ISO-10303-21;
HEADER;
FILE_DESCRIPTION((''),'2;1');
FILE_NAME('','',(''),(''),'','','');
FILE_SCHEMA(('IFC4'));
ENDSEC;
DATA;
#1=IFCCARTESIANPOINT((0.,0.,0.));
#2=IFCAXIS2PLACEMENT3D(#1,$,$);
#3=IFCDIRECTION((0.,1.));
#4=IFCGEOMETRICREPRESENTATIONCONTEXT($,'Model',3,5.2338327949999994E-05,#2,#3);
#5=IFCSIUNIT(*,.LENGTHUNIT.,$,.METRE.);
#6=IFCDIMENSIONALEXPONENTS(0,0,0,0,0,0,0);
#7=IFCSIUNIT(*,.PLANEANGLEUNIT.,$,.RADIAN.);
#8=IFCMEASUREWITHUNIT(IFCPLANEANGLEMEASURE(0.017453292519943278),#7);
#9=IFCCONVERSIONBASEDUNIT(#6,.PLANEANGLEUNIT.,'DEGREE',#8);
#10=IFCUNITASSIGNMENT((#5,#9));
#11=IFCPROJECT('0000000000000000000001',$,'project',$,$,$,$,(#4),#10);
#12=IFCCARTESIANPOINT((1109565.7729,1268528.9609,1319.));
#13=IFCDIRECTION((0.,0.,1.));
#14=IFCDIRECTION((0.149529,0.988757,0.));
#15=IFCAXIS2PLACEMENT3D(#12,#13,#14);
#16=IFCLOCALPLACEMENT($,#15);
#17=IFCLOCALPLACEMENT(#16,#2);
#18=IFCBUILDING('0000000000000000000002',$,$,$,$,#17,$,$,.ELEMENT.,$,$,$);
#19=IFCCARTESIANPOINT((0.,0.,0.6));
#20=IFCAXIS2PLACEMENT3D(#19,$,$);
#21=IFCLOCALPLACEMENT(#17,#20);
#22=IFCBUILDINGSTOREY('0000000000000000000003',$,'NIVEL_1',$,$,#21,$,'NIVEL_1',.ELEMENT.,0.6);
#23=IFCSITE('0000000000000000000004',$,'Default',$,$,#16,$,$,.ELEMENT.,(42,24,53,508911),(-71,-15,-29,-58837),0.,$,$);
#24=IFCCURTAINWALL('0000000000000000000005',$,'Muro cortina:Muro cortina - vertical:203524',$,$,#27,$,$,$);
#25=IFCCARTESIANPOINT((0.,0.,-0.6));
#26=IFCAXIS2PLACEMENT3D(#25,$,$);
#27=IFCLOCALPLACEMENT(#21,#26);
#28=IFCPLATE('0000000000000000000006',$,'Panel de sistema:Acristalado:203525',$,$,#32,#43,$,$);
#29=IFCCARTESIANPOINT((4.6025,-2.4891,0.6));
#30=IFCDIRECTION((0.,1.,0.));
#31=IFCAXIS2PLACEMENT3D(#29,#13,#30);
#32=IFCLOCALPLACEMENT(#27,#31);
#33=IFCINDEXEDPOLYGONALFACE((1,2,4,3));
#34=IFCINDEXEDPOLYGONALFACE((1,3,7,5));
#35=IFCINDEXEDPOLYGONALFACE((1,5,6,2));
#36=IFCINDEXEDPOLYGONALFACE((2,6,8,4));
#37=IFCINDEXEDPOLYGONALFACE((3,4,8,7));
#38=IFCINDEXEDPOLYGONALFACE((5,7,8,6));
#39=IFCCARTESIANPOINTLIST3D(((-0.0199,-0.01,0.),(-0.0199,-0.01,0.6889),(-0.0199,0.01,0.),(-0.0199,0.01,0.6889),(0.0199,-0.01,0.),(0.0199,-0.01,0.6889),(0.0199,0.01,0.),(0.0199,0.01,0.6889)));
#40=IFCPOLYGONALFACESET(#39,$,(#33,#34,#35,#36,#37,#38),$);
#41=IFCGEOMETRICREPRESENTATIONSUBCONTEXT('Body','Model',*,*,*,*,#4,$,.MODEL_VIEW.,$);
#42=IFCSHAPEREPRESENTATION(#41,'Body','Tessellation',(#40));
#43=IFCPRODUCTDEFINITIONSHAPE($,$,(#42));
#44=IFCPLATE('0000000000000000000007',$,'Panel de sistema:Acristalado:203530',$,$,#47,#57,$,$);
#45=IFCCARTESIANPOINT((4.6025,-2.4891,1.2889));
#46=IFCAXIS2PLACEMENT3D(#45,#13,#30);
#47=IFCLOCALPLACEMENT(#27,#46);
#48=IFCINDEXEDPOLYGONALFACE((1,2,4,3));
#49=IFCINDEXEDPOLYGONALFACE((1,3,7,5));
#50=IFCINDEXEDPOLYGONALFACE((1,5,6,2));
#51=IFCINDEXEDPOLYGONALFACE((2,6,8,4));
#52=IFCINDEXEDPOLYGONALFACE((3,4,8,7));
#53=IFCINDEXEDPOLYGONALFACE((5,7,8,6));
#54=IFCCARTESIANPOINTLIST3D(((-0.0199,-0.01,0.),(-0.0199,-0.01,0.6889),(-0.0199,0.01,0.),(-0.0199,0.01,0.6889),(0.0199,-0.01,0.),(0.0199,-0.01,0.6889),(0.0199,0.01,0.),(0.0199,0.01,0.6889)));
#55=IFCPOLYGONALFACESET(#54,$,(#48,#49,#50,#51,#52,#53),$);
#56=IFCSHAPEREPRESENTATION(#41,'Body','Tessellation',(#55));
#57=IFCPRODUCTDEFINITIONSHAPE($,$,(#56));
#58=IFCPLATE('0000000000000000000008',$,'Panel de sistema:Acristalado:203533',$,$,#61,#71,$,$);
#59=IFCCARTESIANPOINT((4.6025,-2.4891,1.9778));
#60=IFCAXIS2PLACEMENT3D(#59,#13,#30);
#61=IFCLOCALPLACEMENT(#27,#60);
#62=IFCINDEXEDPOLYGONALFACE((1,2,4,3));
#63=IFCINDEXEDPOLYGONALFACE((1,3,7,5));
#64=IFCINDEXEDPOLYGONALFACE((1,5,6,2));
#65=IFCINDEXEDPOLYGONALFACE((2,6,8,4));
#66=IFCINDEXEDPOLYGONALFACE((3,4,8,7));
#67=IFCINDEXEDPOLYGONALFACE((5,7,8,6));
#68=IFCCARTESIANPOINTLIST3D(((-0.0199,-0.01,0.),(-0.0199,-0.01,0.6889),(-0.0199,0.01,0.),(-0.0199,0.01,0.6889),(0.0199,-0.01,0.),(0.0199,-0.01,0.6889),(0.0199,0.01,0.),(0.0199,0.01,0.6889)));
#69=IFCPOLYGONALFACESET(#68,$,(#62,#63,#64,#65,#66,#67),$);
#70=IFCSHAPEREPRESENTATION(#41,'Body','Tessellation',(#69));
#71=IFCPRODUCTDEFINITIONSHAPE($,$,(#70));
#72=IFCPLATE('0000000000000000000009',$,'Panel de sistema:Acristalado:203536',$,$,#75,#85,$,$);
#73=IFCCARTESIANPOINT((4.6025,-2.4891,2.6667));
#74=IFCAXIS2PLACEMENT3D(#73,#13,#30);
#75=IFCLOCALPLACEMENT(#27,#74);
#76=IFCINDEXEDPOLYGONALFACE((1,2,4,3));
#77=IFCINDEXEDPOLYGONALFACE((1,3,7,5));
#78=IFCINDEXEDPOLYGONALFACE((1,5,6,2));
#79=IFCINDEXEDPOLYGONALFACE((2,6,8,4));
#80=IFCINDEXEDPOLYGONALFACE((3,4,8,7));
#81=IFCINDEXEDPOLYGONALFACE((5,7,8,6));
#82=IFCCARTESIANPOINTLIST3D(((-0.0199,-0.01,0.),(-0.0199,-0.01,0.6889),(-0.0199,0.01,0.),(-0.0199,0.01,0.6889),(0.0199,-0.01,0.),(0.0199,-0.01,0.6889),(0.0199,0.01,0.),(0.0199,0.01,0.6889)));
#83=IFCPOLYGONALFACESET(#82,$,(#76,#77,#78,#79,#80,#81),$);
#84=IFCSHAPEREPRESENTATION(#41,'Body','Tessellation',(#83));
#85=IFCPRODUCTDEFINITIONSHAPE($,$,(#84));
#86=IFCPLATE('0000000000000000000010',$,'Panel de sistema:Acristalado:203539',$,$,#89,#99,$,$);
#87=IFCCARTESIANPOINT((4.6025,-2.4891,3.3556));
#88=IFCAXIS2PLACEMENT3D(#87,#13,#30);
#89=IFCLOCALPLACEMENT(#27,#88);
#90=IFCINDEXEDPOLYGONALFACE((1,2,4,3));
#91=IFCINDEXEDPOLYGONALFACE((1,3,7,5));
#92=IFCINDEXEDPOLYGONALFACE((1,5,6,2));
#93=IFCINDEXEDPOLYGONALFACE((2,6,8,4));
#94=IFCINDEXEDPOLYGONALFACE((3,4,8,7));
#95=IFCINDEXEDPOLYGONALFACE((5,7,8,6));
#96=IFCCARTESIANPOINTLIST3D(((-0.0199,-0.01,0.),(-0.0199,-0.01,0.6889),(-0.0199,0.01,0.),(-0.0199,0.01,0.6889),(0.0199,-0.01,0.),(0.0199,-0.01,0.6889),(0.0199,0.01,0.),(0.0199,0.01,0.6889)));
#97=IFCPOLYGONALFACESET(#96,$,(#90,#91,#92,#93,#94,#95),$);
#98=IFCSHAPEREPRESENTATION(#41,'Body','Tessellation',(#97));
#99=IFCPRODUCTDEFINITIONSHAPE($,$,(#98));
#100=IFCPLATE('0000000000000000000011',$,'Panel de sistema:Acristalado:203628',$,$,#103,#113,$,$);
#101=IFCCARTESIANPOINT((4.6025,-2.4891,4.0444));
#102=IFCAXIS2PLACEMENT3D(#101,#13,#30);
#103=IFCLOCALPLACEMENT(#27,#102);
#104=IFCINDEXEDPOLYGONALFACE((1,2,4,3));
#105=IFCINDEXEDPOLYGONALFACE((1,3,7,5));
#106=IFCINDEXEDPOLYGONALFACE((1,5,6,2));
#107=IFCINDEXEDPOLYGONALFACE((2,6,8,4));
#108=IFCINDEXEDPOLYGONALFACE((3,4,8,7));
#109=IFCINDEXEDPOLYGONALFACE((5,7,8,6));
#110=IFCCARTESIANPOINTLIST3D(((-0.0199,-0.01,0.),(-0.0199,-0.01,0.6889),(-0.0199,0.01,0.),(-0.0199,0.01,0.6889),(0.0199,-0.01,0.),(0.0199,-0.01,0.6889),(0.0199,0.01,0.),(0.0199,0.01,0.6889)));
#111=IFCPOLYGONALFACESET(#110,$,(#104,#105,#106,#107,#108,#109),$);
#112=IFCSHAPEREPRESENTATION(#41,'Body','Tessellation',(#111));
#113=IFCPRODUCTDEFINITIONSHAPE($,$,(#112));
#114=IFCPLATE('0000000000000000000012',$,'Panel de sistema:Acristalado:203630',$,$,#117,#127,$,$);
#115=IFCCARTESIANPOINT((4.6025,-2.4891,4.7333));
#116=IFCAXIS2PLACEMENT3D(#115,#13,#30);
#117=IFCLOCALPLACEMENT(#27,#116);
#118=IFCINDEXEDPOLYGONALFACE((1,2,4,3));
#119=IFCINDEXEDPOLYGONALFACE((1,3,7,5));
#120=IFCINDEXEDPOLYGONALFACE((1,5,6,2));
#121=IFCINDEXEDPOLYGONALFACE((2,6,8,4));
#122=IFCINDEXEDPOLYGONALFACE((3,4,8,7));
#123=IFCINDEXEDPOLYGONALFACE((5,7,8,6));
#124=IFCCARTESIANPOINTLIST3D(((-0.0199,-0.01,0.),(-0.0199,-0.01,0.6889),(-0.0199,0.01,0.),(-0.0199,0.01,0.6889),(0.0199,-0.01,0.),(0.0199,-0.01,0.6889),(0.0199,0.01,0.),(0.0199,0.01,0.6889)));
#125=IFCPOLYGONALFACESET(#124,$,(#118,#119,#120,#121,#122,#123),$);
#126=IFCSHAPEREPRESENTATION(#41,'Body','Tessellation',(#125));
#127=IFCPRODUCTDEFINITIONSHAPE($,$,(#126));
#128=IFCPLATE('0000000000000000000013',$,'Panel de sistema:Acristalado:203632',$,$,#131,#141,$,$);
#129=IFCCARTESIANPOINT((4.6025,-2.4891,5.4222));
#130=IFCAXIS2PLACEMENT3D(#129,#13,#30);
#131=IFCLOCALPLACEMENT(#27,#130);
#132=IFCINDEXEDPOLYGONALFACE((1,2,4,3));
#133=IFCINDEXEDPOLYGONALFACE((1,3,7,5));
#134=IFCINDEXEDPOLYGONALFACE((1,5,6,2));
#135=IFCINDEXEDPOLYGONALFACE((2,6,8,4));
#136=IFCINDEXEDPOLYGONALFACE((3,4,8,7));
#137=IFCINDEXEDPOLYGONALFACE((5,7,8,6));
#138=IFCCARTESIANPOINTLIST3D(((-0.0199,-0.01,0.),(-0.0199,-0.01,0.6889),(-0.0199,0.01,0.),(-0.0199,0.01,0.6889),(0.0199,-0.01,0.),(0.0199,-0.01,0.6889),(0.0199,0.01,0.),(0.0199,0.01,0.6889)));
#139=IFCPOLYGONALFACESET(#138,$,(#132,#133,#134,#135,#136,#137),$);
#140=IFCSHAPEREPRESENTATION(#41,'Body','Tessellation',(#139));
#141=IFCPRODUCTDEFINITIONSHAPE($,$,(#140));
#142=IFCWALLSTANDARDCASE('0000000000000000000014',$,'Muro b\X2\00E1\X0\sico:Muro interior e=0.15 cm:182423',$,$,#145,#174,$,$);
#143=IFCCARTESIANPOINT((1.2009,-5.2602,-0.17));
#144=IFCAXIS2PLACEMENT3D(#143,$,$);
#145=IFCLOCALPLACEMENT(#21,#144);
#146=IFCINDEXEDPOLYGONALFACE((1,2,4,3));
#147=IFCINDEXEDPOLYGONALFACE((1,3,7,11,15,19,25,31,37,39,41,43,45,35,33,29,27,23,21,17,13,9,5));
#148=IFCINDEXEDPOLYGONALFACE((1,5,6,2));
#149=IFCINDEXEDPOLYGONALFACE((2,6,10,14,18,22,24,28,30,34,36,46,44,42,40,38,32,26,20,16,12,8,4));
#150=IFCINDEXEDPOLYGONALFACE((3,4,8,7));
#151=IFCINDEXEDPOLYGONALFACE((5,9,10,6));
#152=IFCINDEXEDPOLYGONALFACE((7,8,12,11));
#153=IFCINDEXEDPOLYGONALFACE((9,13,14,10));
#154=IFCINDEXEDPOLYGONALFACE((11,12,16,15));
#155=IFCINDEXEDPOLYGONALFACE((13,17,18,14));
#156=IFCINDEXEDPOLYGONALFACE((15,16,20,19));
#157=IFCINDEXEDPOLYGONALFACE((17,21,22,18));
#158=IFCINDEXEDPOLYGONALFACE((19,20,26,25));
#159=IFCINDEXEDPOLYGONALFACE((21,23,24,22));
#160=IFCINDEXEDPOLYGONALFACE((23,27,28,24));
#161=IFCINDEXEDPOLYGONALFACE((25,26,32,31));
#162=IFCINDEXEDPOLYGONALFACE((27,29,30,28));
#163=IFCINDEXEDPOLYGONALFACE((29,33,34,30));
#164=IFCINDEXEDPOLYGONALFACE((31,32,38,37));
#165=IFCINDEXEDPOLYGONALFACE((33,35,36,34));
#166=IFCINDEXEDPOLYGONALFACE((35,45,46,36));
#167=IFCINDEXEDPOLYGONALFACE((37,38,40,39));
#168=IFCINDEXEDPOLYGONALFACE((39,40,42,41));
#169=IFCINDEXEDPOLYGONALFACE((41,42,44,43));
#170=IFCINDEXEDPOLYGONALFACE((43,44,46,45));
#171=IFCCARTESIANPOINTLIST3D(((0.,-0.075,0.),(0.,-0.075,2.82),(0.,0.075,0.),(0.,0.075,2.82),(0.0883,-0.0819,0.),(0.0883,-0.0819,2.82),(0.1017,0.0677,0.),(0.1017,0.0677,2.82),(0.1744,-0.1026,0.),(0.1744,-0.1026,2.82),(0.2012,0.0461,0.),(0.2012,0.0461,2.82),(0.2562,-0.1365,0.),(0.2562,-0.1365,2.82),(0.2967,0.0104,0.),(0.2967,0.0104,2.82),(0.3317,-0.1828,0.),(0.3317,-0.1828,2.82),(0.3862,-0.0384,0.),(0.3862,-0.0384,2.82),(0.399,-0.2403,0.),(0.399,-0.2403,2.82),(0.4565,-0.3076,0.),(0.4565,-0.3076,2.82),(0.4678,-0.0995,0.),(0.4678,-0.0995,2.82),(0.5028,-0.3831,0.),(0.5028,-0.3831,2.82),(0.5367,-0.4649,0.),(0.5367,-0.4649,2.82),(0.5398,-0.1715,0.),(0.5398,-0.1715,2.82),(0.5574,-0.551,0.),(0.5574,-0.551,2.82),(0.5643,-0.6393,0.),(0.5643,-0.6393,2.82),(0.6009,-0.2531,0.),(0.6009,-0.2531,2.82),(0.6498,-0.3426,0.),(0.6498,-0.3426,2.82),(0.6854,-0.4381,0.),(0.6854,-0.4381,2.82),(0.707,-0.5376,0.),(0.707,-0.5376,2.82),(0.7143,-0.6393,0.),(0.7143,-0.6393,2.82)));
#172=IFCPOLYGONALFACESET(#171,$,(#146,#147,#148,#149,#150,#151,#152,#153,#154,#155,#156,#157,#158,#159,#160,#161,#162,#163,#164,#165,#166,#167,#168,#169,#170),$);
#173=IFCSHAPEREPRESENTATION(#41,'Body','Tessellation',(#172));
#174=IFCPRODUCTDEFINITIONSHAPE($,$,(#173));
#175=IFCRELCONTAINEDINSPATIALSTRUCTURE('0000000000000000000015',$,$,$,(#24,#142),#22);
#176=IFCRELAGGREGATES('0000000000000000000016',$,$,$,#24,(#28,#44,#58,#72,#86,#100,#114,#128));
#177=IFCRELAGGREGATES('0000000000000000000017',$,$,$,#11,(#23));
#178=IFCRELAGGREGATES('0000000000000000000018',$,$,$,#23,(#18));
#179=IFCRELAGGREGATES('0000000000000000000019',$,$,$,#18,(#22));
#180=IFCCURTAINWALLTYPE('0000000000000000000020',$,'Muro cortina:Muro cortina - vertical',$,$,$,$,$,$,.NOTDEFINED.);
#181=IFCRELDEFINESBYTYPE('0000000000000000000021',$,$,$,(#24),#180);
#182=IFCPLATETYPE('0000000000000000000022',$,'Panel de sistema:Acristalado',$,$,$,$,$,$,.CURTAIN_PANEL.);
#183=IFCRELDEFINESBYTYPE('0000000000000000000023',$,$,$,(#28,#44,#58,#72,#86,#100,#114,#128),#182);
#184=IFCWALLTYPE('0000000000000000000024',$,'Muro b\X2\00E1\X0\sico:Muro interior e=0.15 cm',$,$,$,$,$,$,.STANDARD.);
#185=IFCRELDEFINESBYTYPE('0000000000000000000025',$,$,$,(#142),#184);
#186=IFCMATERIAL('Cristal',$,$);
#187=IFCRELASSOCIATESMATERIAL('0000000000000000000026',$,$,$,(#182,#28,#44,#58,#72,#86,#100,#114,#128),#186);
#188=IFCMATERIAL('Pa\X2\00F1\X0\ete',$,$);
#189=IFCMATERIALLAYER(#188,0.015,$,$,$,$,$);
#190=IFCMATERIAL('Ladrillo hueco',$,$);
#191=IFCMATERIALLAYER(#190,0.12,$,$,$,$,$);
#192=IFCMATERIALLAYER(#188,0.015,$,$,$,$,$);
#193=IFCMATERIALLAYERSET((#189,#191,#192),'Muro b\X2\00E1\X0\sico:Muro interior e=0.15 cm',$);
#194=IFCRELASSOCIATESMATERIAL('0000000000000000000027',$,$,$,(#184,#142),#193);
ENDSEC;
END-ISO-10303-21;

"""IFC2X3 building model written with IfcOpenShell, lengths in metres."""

from ifc_helpers import new_model, entity, si_unit, converted_unit, direction, frame, frame_2d, origin, origin_2d_with_axis, place, context, subcontext, project, spatial, polyline, circle_curve, parameter, trimmed, segment, composite_curve, rectangle, outline, extrude, source, transform, mapped, material, layer, layer_set, layer_usage, type_object, type_shapes, element, aggregate, save


model = new_model("IFC2X3")

# Units and contexts
model_context = context("Model", 3, precision=5.2338327949999994e-05, world=origin(), true_north=direction((0.0, 1.0)))
body_context = subcontext(model_context, "Body", "Model", "MODEL_VIEW")
ifc_project = project(units=[si_unit("LENGTHUNIT", "METRE"), converted_unit("PLANEANGLEUNIT", "DEGREE", entity("IfcPlaneAngleMeasure", 0.017453292519943278), si_unit("PLANEANGLEUNIT", "RADIAN"), dimensions=[0, 0, 0, 0, 0, 0, 0])], contexts=[model_context])

# Site, building, storey
site_placement = place(None, frame((1109565.7729, 1268528.9609, 1319.0), z_axis=(0.0, 0.0, 1.0), x_axis=(0.149529, 0.988757, 0.0)))
site = spatial("IfcSite", under=ifc_project, at=site_placement, Name="Default", CompositionType="ELEMENT", RefLatitude=(42, 24, 53, 508911), RefLongitude=(-71, -15, -29, -58837), RefElevation=0.0)
building_placement = place(site_placement, origin())
building = spatial("IfcBuilding", under=site, at=building_placement, CompositionType="ELEMENT")
storey_placement = place(building_placement, frame((0.0, 0.0, 0.6)))
storey = spatial("IfcBuildingStorey", under=building, at=storey_placement, Name="NIVEL_1", LongName="NIVEL_1", CompositionType="ELEMENT", Elevation=0.6)

# Curtain wall, plates
curtain_wall_type = type_object("IfcCurtainWallType", Name="Muro cortina:Muro cortina - vertical", PredefinedType="NOTDEFINED")
curtain_wall_placement = place(storey_placement, frame((0.0, 0.0, -0.6)))
curtain_wall = element("IfcCurtainWall", 1, at=curtain_wall_placement, inside=storey, type_object=curtain_wall_type, Name="Muro cortina:Muro cortina - vertical:203524")
ifc_material_1 = material(Name="Cristal")
plate_type = type_object("IfcPlateType", Name="Panel de sistema:Acristalado", PredefinedType="CURTAIN_PANEL", material=ifc_material_1)
shared_shape_1 = source(origin(), body_context, "Body", "SweptSolid", [
    extrude(rectangle(XDim=0.02, YDim=0.0398, at=origin_2d_with_axis()), frame((0.0, 0.0, 0.0), z_axis=(0.0, 0.0, 1.0), x_axis=(0.0, 1.0, 0.0)), (0.0, 0.0, 1.0), 0.6889),
])
type_shapes(plate_type, [shared_shape_1])
plate_1_placement = place(curtain_wall_placement, frame((4.6025, -2.4891, 0.6), z_axis=(0.0, 0.0, 1.0), x_axis=(0.0, 1.0, 0.0)))
plate_1 = element("IfcPlate", 2, at=plate_1_placement, type_object=plate_type, material=ifc_material_1, Name="Panel de sistema:Acristalado:203525", context=body_context, shape_type="MappedRepresentation", body=[
    mapped(shared_shape_1, transform((0.0, 0.0, 0.0), scale=1.0)),
])
plate_2_placement = place(curtain_wall_placement, frame((4.6025, -2.4891, 1.2889), z_axis=(0.0, 0.0, 1.0), x_axis=(0.0, 1.0, 0.0)))
plate_2 = element("IfcPlate", 3, at=plate_2_placement, type_object=plate_type, material=ifc_material_1, Name="Panel de sistema:Acristalado:203530", context=body_context, shape_type="MappedRepresentation", body=[
    mapped(shared_shape_1, transform((0.0, 0.0, 0.0), scale=1.0)),
])
plate_3_placement = place(curtain_wall_placement, frame((4.6025, -2.4891, 1.9778), z_axis=(0.0, 0.0, 1.0), x_axis=(0.0, 1.0, 0.0)))
plate_3 = element("IfcPlate", 4, at=plate_3_placement, type_object=plate_type, material=ifc_material_1, Name="Panel de sistema:Acristalado:203533", context=body_context, shape_type="MappedRepresentation", body=[
    mapped(shared_shape_1, transform((0.0, 0.0, 0.0), scale=1.0)),
])
plate_4_placement = place(curtain_wall_placement, frame((4.6025, -2.4891, 2.6667), z_axis=(0.0, 0.0, 1.0), x_axis=(0.0, 1.0, 0.0)))
plate_4 = element("IfcPlate", 5, at=plate_4_placement, type_object=plate_type, material=ifc_material_1, Name="Panel de sistema:Acristalado:203536", context=body_context, shape_type="MappedRepresentation", body=[
    mapped(shared_shape_1, transform((0.0, 0.0, 0.0), scale=1.0)),
])
plate_5_placement = place(curtain_wall_placement, frame((4.6025, -2.4891, 3.3556), z_axis=(0.0, 0.0, 1.0), x_axis=(0.0, 1.0, 0.0)))
plate_5 = element("IfcPlate", 6, at=plate_5_placement, type_object=plate_type, material=ifc_material_1, Name="Panel de sistema:Acristalado:203539", context=body_context, shape_type="MappedRepresentation", body=[
    mapped(shared_shape_1, transform((0.0, 0.0, 0.0), scale=1.0)),
])
plate_6_placement = place(curtain_wall_placement, frame((4.6025, -2.4891, 4.0444), z_axis=(0.0, 0.0, 1.0), x_axis=(0.0, 1.0, 0.0)))
plate_6 = element("IfcPlate", 7, at=plate_6_placement, type_object=plate_type, material=ifc_material_1, Name="Panel de sistema:Acristalado:203628", context=body_context, shape_type="MappedRepresentation", body=[
    mapped(shared_shape_1, transform((0.0, 0.0, 0.0), scale=1.0)),
])
plate_7_placement = place(curtain_wall_placement, frame((4.6025, -2.4891, 4.7333), z_axis=(0.0, 0.0, 1.0), x_axis=(0.0, 1.0, 0.0)))
plate_7 = element("IfcPlate", 8, at=plate_7_placement, type_object=plate_type, material=ifc_material_1, Name="Panel de sistema:Acristalado:203630", context=body_context, shape_type="MappedRepresentation", body=[
    mapped(shared_shape_1, transform((0.0, 0.0, 0.0), scale=1.0)),
])
plate_8_placement = place(curtain_wall_placement, frame((4.6025, -2.4891, 5.4222), z_axis=(0.0, 0.0, 1.0), x_axis=(0.0, 1.0, 0.0)))
plate_8 = element("IfcPlate", 9, at=plate_8_placement, type_object=plate_type, material=ifc_material_1, Name="Panel de sistema:Acristalado:203632", context=body_context, shape_type="MappedRepresentation", body=[
    mapped(shared_shape_1, transform((0.0, 0.0, 0.0), scale=1.0)),
])
aggregate(curtain_wall, [plate_1, plate_2, plate_3, plate_4, plate_5, plate_6, plate_7, plate_8])

# Wall
ifc_material_2 = material(Name="Pañete")
ifc_layer_1 = layer(ifc_material_2, 0.015)
ifc_material_3 = material(Name="Ladrillo hueco")
ifc_layer_2 = layer(ifc_material_3, 0.12)
ifc_layer_3 = layer(ifc_material_2, 0.015)
ifc_layer_set_1 = layer_set([ifc_layer_1, ifc_layer_2, ifc_layer_3], Name="Muro básico:Muro interior e=0.15 cm")
ifc_layer_usage_1 = layer_usage(ifc_layer_set_1, "AXIS2", "POSITIVE", -0.075)
wall_type_1 = type_object("IfcWallType", Name="Muro básico:Muro interior e=0.15 cm", PredefinedType="STANDARD", material=ifc_layer_set_1)
wall_1_placement = place(storey_placement, frame((1.2009, -5.2602, -0.17)))
element("IfcWallStandardCase", 10, at=wall_1_placement, inside=storey, type_object=wall_type_1, material=ifc_layer_usage_1, Name="Muro básico:Muro interior e=0.15 cm:182423", context=body_context, shape_type="SweptSolid", body=[
    extrude(outline(composite_curve([segment(trimmed(circle_curve(frame_2d((0.0, -0.6393), x_axis=(1.0, 0.0)), 0.7143), [parameter(360.0)], [parameter(90.0)], True, "PARAMETER"), True, "CONTINUOUS"), segment(polyline([(0.0, 0.075), (0.0, -0.075)]), True, "CONTINUOUS"), segment(trimmed(circle_curve(frame_2d((0.0, -0.6393), x_axis=(1.0, 0.0)), 0.5643), [parameter(0.0)], [parameter(90.0)], True, "PARAMETER"), False, "CONTINUOUS"), segment(polyline([(0.5643, -0.6393), (0.7143, -0.6393)]), True, "CONTINUOUS")], self_intersect=False)), origin(), (0.0, 0.0, 1.0), 2.82),
])

save(model, "model.ifc")
